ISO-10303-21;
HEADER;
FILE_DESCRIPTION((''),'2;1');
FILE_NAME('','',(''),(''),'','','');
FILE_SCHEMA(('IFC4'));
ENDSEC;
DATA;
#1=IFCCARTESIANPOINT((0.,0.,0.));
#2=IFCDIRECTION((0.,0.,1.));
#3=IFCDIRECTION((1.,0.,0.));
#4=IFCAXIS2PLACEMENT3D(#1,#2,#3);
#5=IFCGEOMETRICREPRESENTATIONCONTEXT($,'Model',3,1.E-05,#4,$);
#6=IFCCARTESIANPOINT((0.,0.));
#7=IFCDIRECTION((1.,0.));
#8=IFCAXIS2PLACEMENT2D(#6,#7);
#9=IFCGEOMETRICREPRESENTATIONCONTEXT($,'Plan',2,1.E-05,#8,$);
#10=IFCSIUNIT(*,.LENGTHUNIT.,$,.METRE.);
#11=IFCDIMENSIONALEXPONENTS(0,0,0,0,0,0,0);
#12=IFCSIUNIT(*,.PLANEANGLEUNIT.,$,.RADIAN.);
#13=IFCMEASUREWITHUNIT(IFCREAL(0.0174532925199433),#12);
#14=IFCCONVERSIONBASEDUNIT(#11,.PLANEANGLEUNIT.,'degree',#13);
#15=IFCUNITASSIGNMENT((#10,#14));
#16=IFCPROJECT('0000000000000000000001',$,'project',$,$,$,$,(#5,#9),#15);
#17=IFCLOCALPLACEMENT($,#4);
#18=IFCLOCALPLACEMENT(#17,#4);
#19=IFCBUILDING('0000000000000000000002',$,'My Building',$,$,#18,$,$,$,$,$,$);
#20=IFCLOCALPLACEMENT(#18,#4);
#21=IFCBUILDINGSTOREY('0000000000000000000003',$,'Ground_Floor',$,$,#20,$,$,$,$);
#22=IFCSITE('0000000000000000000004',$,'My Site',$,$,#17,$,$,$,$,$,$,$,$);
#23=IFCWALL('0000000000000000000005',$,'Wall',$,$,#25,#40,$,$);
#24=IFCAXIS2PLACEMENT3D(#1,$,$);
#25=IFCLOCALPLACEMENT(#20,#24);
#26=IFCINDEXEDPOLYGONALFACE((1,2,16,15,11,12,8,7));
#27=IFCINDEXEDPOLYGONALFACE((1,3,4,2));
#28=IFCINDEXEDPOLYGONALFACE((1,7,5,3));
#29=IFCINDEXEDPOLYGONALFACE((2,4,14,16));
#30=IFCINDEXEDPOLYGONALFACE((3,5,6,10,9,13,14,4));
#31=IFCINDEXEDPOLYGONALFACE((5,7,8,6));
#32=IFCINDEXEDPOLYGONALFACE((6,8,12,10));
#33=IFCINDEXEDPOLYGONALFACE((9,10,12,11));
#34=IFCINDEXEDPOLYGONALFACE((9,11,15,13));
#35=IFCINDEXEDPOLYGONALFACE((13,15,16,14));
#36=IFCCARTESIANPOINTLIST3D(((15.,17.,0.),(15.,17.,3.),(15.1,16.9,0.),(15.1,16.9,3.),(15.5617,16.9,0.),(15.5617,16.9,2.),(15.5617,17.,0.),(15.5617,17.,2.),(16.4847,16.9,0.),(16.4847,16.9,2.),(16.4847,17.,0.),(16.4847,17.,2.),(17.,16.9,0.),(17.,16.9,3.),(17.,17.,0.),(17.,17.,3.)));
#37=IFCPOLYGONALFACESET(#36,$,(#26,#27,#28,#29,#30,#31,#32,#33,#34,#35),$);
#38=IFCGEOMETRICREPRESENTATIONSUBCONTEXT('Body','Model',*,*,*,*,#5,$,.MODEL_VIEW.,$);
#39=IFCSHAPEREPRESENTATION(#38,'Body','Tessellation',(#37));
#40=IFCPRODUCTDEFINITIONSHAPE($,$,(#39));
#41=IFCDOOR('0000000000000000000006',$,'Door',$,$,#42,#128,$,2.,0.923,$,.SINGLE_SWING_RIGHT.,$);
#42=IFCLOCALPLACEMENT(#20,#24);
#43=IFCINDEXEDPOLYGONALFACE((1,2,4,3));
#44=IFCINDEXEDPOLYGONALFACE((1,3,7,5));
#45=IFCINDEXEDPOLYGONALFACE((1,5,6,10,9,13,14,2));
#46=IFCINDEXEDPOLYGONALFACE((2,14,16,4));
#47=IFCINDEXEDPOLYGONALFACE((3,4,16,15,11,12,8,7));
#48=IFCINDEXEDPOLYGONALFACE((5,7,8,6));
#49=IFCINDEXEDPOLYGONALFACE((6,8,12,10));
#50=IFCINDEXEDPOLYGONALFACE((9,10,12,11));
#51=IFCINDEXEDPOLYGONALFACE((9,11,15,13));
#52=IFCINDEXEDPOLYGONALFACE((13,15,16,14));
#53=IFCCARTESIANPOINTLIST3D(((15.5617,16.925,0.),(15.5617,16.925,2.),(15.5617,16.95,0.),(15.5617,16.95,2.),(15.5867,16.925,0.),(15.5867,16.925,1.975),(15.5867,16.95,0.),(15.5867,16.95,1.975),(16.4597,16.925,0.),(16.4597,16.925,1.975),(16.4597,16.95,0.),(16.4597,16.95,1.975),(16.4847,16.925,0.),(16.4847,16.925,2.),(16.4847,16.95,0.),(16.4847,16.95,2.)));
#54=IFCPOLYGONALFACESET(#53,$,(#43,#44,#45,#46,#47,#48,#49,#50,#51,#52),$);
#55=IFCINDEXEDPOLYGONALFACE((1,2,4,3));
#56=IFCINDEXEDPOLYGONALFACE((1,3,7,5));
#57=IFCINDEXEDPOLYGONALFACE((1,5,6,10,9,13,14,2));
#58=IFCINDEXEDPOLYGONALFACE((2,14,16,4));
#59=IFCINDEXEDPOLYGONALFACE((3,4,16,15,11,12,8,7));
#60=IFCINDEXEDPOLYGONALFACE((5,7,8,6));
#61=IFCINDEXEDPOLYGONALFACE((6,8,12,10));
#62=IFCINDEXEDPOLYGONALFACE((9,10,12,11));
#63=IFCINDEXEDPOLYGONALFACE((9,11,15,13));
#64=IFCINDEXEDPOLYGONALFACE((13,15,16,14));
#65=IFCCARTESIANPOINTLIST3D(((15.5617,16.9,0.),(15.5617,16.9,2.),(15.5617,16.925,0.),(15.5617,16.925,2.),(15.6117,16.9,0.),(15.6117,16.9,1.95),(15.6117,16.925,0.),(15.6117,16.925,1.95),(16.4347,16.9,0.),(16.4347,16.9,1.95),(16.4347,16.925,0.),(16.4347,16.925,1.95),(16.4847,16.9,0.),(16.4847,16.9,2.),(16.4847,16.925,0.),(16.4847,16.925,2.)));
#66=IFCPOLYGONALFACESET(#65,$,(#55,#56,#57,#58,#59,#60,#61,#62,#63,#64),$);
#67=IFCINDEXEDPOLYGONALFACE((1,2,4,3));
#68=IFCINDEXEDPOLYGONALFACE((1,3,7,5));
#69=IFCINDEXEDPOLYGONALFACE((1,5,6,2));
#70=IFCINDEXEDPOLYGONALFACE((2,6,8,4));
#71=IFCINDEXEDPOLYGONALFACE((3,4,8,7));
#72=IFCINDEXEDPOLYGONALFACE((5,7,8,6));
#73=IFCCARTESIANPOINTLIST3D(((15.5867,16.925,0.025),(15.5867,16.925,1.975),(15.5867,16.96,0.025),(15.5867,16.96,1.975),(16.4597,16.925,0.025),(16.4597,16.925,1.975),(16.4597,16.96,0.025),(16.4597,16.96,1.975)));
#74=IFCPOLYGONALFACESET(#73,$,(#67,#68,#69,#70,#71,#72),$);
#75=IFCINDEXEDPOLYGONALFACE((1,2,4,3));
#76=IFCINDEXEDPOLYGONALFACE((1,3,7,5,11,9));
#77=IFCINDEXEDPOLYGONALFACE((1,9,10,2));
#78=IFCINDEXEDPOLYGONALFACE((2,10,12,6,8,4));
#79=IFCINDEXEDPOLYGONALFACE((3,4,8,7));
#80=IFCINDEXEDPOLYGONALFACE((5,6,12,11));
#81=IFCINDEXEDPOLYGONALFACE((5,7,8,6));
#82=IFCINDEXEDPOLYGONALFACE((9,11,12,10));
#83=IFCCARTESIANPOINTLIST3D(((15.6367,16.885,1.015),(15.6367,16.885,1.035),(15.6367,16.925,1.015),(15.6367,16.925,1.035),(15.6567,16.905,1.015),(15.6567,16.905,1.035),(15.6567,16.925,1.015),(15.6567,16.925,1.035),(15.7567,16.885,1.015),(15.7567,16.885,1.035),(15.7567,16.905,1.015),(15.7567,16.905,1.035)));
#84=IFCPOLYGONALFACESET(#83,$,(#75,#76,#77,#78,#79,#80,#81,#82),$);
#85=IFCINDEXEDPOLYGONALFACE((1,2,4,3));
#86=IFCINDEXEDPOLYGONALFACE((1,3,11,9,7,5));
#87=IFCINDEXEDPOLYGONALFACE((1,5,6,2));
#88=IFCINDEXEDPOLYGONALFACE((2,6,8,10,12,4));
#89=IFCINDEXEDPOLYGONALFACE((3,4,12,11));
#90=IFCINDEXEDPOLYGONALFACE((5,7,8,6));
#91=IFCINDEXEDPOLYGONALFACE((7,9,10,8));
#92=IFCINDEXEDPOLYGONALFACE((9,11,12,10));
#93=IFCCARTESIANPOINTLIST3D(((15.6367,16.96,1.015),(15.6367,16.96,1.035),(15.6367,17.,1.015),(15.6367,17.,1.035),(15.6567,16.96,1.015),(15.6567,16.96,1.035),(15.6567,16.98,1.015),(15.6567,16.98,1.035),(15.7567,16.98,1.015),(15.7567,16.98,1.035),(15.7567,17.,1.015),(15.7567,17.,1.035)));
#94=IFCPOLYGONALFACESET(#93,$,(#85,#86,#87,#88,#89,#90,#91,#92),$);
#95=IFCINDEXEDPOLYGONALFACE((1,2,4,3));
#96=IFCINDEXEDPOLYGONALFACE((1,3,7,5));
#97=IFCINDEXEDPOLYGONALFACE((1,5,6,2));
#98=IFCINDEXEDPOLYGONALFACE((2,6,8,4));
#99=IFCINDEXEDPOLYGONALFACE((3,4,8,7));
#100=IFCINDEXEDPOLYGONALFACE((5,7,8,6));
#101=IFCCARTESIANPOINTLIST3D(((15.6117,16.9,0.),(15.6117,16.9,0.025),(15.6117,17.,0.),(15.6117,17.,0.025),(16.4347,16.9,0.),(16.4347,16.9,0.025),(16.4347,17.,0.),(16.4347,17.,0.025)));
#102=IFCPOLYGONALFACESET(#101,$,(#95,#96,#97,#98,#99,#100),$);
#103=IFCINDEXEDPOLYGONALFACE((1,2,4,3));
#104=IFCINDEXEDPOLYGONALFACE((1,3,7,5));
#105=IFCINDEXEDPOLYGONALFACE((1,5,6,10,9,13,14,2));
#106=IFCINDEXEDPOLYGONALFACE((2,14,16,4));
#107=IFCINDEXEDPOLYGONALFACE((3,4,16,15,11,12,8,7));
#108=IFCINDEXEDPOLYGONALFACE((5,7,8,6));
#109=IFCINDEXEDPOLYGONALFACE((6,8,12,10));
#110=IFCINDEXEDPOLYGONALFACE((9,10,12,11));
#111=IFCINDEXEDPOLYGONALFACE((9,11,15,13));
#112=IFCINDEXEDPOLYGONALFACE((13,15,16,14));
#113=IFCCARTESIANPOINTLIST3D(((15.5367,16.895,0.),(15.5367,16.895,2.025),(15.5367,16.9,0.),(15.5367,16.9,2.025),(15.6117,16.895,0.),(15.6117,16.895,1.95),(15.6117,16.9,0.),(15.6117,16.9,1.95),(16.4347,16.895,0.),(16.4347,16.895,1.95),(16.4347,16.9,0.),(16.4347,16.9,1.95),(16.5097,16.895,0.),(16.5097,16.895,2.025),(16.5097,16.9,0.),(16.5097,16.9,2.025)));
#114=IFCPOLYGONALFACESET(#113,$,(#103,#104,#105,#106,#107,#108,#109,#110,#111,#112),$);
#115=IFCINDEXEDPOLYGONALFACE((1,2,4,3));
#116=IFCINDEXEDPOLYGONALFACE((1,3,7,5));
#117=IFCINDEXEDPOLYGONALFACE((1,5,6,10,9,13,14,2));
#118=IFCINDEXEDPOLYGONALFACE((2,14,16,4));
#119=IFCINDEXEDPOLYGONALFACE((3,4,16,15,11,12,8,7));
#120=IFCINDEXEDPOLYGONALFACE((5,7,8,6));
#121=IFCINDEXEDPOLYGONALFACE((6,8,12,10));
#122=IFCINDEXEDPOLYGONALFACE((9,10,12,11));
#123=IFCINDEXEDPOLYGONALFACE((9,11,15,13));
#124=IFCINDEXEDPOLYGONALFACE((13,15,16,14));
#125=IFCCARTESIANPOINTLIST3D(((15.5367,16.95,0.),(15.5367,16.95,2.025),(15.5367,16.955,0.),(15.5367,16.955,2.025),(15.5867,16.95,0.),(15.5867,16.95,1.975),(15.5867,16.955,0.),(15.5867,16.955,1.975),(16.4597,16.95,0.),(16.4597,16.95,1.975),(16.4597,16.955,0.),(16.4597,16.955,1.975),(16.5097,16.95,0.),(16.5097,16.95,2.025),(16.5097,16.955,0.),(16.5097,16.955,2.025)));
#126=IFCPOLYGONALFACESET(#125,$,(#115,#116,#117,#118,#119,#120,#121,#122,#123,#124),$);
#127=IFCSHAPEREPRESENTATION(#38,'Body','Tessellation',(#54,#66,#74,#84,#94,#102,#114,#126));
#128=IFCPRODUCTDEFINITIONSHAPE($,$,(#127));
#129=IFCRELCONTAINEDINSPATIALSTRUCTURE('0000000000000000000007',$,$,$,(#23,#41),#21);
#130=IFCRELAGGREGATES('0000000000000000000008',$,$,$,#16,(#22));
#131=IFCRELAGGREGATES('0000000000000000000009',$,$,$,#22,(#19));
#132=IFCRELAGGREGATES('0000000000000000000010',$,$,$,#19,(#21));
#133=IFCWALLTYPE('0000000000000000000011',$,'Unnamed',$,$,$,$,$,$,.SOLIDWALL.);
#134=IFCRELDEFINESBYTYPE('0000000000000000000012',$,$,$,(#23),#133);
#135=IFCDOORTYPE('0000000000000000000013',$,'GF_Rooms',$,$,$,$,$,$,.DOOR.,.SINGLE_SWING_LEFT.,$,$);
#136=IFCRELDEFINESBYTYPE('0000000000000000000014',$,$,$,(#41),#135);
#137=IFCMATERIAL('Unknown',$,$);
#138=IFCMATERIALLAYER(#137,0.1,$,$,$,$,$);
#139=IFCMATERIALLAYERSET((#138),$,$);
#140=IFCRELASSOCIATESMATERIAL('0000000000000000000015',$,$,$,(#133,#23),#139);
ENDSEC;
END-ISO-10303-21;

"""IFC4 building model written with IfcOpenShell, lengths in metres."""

from ifc_helpers import new_model, entity, si_unit, converted_unit, frame, origin_with_axes, origin_2d_with_axis, place, context, subcontext, project, spatial, line, indexed_curve, outline, extrude, shape, source, transform, mapped, material, layer, layer_set, layer_usage, type_object, type_shapes, element, fill, save


model = new_model("IFC4")

# Units and contexts
model_context = context("Model", 3, precision=1e-05, world=origin_with_axes())
plan_context = context("Plan", 2, precision=1e-05, world=origin_2d_with_axis())
body_context_1 = subcontext(model_context, "Body", "Model", "MODEL_VIEW")
body_context_2 = subcontext(plan_context, "Body", "Plan", "PLAN_VIEW")
ifc_project = project(units=[si_unit("LENGTHUNIT", "METRE"), converted_unit("PLANEANGLEUNIT", "degree", entity("IfcReal", 0.0174532925199433), si_unit("PLANEANGLEUNIT", "RADIAN"), dimensions=[0, 0, 0, 0, 0, 0, 0])], contexts=[model_context, plan_context])

# Site, building, storey
site_placement = place(None, origin_with_axes())
site = spatial("IfcSite", under=ifc_project, at=site_placement, Name="My Site")
building_placement = place(site_placement, origin_with_axes())
building = spatial("IfcBuilding", under=site, at=building_placement, Name="My Building")
storey_placement = place(building_placement, origin_with_axes())
storey = spatial("IfcBuildingStorey", under=building, at=storey_placement, Name="Ground_Floor")

# Shared definitions
ifc_material = material(Name="Unknown")
ifc_layer = layer(ifc_material, 0.1)
ifc_layer_set = layer_set([ifc_layer])
wall_type = type_object("IfcWallType", Name="Unnamed", PredefinedType="SOLIDWALL", material=ifc_layer_set)

# Wall, opening, door
shared_shape_1 = source(origin_with_axes(), body_context_1, "Body", "SweptSolid", [
    extrude(outline(indexed_curve([(0.0, 0.0), (0.923, 0.0), (0.923, 2.0), (0.0, 2.0)], segments=[line(1, 2, 3, 4, 1)])), frame((0.0, -0.6, 0.0), z_axis=(0.0, -1.0, 0.0), x_axis=(1.0, 0.0, 0.0)), (0.0, 0.0, -1.0), 1.2),
])
door_type_1 = type_object("IfcDoorType", Name="GF_Rooms", OperationType="SINGLE_SWING_LEFT", PredefinedType="DOOR")
shared_shape_2 = source(origin_with_axes(), body_context_1, "Body", "SweptSolid", [
    extrude(outline(indexed_curve([(0.0, 0.0), (0.0, 2.0), (0.923, 2.0), (0.923, 0.0), (0.898, 0.0), (0.898, 1.975), (0.025, 1.975), (0.025, 0.0)], segments=[line(1, 2, 3, 4, 5, 6, 7, 8, 1)])), frame((0.0, 0.025, 0.0), z_axis=(0.0, -1.0, 0.0), x_axis=(1.0, 0.0, 0.0)), (0.0, 0.0, -1.0), 0.025),
    extrude(outline(indexed_curve([(0.0, 0.0), (0.0, 2.0), (0.923, 2.0), (0.923, 0.0), (0.873, 0.0), (0.873, 1.95), (0.05, 1.95), (0.05, 0.0)], segments=[line(1, 2, 3, 4, 5, 6, 7, 8, 1)])), frame((0.0, 0.0, 0.0), z_axis=(0.0, -1.0, 0.0), x_axis=(1.0, 0.0, 0.0)), (0.0, 0.0, -1.0), 0.025),
    extrude(outline(indexed_curve([(0.0, 0.0), (0.873, 0.0), (0.873, 0.035), (0.0, 0.035)], segments=[line(1, 2, 3, 4, 1)])), frame((0.025, 0.025, 0.025), z_axis=(0.0, 0.0, 1.0), x_axis=(1.0, 0.0, 0.0)), (0.0, 0.0, 1.0), 1.95),
    extrude(outline(indexed_curve([(0.0, 0.0), (0.0, -0.04), (0.12, -0.04), (0.12, -0.02), (0.02, -0.02), (0.02, 0.0)], segments=[line(1, 2, 3, 4, 5, 6, 1)])), frame((0.075, 0.025, 1.015), z_axis=(0.0, 0.0, 1.0), x_axis=(1.0, 0.0, 0.0)), (0.0, 0.0, 1.0), 0.02),
    extrude(outline(indexed_curve([(0.0, 0.0), (0.0, 0.04), (0.12, 0.04), (0.12, 0.02), (0.02, 0.02), (0.02, 0.0)], segments=[line(1, 2, 3, 4, 5, 6, 1)])), frame((0.075, 0.06, 1.015), z_axis=(0.0, 0.0, 1.0), x_axis=(1.0, 0.0, 0.0)), (0.0, 0.0, 1.0), 0.02),
    extrude(outline(indexed_curve([(0.0, 0.0), (0.823, 0.0), (0.823, 0.1), (0.0, 0.1)], segments=[line(1, 2, 3, 4, 1)])), frame((0.05, 0.0, 0.0), z_axis=(0.0, 0.0, 1.0), x_axis=(1.0, 0.0, 0.0)), (0.0, 0.0, 1.0), 0.025),
    extrude(outline(indexed_curve([(0.0, 0.0), (0.0, 2.025), (0.973, 2.025), (0.973, 0.0), (0.898, 0.0), (0.898, 1.95), (0.075, 1.95), (0.075, 0.0)], segments=[line(1, 2, 3, 4, 5, 6, 7, 8, 1)])), frame((-0.025, -0.005, 0.0), z_axis=(0.0, -1.0, 0.0), x_axis=(1.0, 0.0, 0.0)), (0.0, 0.0, -1.0), 0.005),
    extrude(outline(indexed_curve([(0.0, 0.0), (0.0, 2.025), (0.973, 2.025), (0.973, 0.0), (0.923, 0.0), (0.923, 1.975), (0.05, 1.975), (0.05, 0.0)], segments=[line(1, 2, 3, 4, 5, 6, 7, 8, 1)])), frame((-0.025, 0.05, 0.0), z_axis=(0.0, -1.0, 0.0), x_axis=(1.0, 0.0, 0.0)), (0.0, 0.0, -1.0), 0.005),
])
shared_shape_3 = source(origin_with_axes(), body_context_2, "Body", "Curve2D", [
    entity("IfcIndexedPolyCurve", entity("IfcCartesianPointList2D", [[0.0, 0.0], [0.0, 0.05], [0.025, 0.05], [0.025, 0.025], [0.05, 0.025], [0.05, 0.0]]), [entity("IfcLineIndex", [1, 2, 3, 4, 5, 6, 1])]),
    entity("IfcIndexedPolyCurve", entity("IfcCartesianPointList2D", [[0.923, 0.0], [0.923, 0.05], [0.898, 0.05], [0.898, 0.025], [0.873, 0.025], [0.873, 0.0]]), [entity("IfcLineIndex", [1, 2, 3, 4, 5, 6, 1])]),
    entity("IfcTrimmedCurve", entity("IfcEllipse", entity("IfcAxis2Placement2D", entity("IfcCartesianPoint", [0.863, 0.05]), entity("IfcDirection", [1.0, 0.0])), 0.838, 0.873), [entity("IfcCartesianPoint", [0.863, 0.923])], [entity("IfcCartesianPoint", [0.025, 0.05])], True, "CARTESIAN"),
    entity("IfcIndexedPolyCurve", entity("IfcCartesianPointList2D", [[0.898, 0.05], [0.863, 0.05], [0.863, 0.923], [0.898, 0.923]]), [entity("IfcLineIndex", [1, 2, 3, 4, 1])]),
])
type_shapes(door_type_1, [shared_shape_2, shared_shape_3])
ifc_layer_usage_1 = layer_usage(ifc_layer_set, "AXIS2", "POSITIVE", 0.0)
wall_1_placement = place(storey_placement, frame((17.0, 17.0, 0.0), z_axis=(0.0, 0.0, 1.0), x_axis=(-1.0, 0.0, 0.0)))
wall_1 = element("IfcWall", 1, at=wall_1_placement, inside=storey, type_object=wall_type, material=ifc_layer_usage_1, Name="Wall", context=body_context_1, shape_type="SweptSolid", body=[
    extrude(outline(indexed_curve([(0.0, 0.0), (0.0, 0.1), (1.9, 0.1), (2.0, 0.0)], segments=[line(1, 2, 3, 4, 1)])), origin_with_axes(), (0.0, 0.0, 1.0), 3.0),
])
opening_1_placement = place(wall_1_placement, frame((1.4383, 0.1, 0.0), z_axis=(0.0, 0.0, 1.0), x_axis=(-1.0, 0.0, 0.0)))
opening_1 = element("IfcOpeningElement", 2, at=opening_1_placement, cuts=wall_1, PredefinedType="OPENING", context=body_context_1, shape_type="MappedRepresentation", body=[
    mapped(shared_shape_1, transform((0.0, 0.0, 0.0), x_axis=(1.0, 0.0, 0.0), y_axis=(0.0, 1.0, 0.0), z_axis=(0.0, 0.0, 1.0), scale=1.0)),
])
door_1_placement = place(opening_1_placement, frame((0.0, 0.0, 0.0), z_axis=(0.0, 0.0, 1.0), x_axis=(1.0, 0.0, 0.0)))
door_1 = element("IfcDoor", 3, at=door_1_placement, inside=storey, type_object=door_type_1, Name="Door", OperationType="SINGLE_SWING_RIGHT", OverallHeight=2.0, OverallWidth=0.923, shapes=[
    shape(body_context_1, "Body", "MappedRepresentation", [mapped(shared_shape_2, transform((0.0, 0.0, 0.0), x_axis=(1.0, 0.0, 0.0), y_axis=(0.0, 1.0, 0.0), z_axis=(0.0, 0.0, 1.0), scale=1.0))]),
    shape(body_context_2, "Body", "MappedRepresentation", [mapped(shared_shape_3, transform((0.0, 0.0, 0.0), x_axis=(1.0, 0.0, 0.0), y_axis=(0.0, 1.0, 0.0), z_axis=(0.0, 0.0, 1.0), scale=1.0))]),
])
fill(opening_1, door_1)

save(model, "model.ifc")
